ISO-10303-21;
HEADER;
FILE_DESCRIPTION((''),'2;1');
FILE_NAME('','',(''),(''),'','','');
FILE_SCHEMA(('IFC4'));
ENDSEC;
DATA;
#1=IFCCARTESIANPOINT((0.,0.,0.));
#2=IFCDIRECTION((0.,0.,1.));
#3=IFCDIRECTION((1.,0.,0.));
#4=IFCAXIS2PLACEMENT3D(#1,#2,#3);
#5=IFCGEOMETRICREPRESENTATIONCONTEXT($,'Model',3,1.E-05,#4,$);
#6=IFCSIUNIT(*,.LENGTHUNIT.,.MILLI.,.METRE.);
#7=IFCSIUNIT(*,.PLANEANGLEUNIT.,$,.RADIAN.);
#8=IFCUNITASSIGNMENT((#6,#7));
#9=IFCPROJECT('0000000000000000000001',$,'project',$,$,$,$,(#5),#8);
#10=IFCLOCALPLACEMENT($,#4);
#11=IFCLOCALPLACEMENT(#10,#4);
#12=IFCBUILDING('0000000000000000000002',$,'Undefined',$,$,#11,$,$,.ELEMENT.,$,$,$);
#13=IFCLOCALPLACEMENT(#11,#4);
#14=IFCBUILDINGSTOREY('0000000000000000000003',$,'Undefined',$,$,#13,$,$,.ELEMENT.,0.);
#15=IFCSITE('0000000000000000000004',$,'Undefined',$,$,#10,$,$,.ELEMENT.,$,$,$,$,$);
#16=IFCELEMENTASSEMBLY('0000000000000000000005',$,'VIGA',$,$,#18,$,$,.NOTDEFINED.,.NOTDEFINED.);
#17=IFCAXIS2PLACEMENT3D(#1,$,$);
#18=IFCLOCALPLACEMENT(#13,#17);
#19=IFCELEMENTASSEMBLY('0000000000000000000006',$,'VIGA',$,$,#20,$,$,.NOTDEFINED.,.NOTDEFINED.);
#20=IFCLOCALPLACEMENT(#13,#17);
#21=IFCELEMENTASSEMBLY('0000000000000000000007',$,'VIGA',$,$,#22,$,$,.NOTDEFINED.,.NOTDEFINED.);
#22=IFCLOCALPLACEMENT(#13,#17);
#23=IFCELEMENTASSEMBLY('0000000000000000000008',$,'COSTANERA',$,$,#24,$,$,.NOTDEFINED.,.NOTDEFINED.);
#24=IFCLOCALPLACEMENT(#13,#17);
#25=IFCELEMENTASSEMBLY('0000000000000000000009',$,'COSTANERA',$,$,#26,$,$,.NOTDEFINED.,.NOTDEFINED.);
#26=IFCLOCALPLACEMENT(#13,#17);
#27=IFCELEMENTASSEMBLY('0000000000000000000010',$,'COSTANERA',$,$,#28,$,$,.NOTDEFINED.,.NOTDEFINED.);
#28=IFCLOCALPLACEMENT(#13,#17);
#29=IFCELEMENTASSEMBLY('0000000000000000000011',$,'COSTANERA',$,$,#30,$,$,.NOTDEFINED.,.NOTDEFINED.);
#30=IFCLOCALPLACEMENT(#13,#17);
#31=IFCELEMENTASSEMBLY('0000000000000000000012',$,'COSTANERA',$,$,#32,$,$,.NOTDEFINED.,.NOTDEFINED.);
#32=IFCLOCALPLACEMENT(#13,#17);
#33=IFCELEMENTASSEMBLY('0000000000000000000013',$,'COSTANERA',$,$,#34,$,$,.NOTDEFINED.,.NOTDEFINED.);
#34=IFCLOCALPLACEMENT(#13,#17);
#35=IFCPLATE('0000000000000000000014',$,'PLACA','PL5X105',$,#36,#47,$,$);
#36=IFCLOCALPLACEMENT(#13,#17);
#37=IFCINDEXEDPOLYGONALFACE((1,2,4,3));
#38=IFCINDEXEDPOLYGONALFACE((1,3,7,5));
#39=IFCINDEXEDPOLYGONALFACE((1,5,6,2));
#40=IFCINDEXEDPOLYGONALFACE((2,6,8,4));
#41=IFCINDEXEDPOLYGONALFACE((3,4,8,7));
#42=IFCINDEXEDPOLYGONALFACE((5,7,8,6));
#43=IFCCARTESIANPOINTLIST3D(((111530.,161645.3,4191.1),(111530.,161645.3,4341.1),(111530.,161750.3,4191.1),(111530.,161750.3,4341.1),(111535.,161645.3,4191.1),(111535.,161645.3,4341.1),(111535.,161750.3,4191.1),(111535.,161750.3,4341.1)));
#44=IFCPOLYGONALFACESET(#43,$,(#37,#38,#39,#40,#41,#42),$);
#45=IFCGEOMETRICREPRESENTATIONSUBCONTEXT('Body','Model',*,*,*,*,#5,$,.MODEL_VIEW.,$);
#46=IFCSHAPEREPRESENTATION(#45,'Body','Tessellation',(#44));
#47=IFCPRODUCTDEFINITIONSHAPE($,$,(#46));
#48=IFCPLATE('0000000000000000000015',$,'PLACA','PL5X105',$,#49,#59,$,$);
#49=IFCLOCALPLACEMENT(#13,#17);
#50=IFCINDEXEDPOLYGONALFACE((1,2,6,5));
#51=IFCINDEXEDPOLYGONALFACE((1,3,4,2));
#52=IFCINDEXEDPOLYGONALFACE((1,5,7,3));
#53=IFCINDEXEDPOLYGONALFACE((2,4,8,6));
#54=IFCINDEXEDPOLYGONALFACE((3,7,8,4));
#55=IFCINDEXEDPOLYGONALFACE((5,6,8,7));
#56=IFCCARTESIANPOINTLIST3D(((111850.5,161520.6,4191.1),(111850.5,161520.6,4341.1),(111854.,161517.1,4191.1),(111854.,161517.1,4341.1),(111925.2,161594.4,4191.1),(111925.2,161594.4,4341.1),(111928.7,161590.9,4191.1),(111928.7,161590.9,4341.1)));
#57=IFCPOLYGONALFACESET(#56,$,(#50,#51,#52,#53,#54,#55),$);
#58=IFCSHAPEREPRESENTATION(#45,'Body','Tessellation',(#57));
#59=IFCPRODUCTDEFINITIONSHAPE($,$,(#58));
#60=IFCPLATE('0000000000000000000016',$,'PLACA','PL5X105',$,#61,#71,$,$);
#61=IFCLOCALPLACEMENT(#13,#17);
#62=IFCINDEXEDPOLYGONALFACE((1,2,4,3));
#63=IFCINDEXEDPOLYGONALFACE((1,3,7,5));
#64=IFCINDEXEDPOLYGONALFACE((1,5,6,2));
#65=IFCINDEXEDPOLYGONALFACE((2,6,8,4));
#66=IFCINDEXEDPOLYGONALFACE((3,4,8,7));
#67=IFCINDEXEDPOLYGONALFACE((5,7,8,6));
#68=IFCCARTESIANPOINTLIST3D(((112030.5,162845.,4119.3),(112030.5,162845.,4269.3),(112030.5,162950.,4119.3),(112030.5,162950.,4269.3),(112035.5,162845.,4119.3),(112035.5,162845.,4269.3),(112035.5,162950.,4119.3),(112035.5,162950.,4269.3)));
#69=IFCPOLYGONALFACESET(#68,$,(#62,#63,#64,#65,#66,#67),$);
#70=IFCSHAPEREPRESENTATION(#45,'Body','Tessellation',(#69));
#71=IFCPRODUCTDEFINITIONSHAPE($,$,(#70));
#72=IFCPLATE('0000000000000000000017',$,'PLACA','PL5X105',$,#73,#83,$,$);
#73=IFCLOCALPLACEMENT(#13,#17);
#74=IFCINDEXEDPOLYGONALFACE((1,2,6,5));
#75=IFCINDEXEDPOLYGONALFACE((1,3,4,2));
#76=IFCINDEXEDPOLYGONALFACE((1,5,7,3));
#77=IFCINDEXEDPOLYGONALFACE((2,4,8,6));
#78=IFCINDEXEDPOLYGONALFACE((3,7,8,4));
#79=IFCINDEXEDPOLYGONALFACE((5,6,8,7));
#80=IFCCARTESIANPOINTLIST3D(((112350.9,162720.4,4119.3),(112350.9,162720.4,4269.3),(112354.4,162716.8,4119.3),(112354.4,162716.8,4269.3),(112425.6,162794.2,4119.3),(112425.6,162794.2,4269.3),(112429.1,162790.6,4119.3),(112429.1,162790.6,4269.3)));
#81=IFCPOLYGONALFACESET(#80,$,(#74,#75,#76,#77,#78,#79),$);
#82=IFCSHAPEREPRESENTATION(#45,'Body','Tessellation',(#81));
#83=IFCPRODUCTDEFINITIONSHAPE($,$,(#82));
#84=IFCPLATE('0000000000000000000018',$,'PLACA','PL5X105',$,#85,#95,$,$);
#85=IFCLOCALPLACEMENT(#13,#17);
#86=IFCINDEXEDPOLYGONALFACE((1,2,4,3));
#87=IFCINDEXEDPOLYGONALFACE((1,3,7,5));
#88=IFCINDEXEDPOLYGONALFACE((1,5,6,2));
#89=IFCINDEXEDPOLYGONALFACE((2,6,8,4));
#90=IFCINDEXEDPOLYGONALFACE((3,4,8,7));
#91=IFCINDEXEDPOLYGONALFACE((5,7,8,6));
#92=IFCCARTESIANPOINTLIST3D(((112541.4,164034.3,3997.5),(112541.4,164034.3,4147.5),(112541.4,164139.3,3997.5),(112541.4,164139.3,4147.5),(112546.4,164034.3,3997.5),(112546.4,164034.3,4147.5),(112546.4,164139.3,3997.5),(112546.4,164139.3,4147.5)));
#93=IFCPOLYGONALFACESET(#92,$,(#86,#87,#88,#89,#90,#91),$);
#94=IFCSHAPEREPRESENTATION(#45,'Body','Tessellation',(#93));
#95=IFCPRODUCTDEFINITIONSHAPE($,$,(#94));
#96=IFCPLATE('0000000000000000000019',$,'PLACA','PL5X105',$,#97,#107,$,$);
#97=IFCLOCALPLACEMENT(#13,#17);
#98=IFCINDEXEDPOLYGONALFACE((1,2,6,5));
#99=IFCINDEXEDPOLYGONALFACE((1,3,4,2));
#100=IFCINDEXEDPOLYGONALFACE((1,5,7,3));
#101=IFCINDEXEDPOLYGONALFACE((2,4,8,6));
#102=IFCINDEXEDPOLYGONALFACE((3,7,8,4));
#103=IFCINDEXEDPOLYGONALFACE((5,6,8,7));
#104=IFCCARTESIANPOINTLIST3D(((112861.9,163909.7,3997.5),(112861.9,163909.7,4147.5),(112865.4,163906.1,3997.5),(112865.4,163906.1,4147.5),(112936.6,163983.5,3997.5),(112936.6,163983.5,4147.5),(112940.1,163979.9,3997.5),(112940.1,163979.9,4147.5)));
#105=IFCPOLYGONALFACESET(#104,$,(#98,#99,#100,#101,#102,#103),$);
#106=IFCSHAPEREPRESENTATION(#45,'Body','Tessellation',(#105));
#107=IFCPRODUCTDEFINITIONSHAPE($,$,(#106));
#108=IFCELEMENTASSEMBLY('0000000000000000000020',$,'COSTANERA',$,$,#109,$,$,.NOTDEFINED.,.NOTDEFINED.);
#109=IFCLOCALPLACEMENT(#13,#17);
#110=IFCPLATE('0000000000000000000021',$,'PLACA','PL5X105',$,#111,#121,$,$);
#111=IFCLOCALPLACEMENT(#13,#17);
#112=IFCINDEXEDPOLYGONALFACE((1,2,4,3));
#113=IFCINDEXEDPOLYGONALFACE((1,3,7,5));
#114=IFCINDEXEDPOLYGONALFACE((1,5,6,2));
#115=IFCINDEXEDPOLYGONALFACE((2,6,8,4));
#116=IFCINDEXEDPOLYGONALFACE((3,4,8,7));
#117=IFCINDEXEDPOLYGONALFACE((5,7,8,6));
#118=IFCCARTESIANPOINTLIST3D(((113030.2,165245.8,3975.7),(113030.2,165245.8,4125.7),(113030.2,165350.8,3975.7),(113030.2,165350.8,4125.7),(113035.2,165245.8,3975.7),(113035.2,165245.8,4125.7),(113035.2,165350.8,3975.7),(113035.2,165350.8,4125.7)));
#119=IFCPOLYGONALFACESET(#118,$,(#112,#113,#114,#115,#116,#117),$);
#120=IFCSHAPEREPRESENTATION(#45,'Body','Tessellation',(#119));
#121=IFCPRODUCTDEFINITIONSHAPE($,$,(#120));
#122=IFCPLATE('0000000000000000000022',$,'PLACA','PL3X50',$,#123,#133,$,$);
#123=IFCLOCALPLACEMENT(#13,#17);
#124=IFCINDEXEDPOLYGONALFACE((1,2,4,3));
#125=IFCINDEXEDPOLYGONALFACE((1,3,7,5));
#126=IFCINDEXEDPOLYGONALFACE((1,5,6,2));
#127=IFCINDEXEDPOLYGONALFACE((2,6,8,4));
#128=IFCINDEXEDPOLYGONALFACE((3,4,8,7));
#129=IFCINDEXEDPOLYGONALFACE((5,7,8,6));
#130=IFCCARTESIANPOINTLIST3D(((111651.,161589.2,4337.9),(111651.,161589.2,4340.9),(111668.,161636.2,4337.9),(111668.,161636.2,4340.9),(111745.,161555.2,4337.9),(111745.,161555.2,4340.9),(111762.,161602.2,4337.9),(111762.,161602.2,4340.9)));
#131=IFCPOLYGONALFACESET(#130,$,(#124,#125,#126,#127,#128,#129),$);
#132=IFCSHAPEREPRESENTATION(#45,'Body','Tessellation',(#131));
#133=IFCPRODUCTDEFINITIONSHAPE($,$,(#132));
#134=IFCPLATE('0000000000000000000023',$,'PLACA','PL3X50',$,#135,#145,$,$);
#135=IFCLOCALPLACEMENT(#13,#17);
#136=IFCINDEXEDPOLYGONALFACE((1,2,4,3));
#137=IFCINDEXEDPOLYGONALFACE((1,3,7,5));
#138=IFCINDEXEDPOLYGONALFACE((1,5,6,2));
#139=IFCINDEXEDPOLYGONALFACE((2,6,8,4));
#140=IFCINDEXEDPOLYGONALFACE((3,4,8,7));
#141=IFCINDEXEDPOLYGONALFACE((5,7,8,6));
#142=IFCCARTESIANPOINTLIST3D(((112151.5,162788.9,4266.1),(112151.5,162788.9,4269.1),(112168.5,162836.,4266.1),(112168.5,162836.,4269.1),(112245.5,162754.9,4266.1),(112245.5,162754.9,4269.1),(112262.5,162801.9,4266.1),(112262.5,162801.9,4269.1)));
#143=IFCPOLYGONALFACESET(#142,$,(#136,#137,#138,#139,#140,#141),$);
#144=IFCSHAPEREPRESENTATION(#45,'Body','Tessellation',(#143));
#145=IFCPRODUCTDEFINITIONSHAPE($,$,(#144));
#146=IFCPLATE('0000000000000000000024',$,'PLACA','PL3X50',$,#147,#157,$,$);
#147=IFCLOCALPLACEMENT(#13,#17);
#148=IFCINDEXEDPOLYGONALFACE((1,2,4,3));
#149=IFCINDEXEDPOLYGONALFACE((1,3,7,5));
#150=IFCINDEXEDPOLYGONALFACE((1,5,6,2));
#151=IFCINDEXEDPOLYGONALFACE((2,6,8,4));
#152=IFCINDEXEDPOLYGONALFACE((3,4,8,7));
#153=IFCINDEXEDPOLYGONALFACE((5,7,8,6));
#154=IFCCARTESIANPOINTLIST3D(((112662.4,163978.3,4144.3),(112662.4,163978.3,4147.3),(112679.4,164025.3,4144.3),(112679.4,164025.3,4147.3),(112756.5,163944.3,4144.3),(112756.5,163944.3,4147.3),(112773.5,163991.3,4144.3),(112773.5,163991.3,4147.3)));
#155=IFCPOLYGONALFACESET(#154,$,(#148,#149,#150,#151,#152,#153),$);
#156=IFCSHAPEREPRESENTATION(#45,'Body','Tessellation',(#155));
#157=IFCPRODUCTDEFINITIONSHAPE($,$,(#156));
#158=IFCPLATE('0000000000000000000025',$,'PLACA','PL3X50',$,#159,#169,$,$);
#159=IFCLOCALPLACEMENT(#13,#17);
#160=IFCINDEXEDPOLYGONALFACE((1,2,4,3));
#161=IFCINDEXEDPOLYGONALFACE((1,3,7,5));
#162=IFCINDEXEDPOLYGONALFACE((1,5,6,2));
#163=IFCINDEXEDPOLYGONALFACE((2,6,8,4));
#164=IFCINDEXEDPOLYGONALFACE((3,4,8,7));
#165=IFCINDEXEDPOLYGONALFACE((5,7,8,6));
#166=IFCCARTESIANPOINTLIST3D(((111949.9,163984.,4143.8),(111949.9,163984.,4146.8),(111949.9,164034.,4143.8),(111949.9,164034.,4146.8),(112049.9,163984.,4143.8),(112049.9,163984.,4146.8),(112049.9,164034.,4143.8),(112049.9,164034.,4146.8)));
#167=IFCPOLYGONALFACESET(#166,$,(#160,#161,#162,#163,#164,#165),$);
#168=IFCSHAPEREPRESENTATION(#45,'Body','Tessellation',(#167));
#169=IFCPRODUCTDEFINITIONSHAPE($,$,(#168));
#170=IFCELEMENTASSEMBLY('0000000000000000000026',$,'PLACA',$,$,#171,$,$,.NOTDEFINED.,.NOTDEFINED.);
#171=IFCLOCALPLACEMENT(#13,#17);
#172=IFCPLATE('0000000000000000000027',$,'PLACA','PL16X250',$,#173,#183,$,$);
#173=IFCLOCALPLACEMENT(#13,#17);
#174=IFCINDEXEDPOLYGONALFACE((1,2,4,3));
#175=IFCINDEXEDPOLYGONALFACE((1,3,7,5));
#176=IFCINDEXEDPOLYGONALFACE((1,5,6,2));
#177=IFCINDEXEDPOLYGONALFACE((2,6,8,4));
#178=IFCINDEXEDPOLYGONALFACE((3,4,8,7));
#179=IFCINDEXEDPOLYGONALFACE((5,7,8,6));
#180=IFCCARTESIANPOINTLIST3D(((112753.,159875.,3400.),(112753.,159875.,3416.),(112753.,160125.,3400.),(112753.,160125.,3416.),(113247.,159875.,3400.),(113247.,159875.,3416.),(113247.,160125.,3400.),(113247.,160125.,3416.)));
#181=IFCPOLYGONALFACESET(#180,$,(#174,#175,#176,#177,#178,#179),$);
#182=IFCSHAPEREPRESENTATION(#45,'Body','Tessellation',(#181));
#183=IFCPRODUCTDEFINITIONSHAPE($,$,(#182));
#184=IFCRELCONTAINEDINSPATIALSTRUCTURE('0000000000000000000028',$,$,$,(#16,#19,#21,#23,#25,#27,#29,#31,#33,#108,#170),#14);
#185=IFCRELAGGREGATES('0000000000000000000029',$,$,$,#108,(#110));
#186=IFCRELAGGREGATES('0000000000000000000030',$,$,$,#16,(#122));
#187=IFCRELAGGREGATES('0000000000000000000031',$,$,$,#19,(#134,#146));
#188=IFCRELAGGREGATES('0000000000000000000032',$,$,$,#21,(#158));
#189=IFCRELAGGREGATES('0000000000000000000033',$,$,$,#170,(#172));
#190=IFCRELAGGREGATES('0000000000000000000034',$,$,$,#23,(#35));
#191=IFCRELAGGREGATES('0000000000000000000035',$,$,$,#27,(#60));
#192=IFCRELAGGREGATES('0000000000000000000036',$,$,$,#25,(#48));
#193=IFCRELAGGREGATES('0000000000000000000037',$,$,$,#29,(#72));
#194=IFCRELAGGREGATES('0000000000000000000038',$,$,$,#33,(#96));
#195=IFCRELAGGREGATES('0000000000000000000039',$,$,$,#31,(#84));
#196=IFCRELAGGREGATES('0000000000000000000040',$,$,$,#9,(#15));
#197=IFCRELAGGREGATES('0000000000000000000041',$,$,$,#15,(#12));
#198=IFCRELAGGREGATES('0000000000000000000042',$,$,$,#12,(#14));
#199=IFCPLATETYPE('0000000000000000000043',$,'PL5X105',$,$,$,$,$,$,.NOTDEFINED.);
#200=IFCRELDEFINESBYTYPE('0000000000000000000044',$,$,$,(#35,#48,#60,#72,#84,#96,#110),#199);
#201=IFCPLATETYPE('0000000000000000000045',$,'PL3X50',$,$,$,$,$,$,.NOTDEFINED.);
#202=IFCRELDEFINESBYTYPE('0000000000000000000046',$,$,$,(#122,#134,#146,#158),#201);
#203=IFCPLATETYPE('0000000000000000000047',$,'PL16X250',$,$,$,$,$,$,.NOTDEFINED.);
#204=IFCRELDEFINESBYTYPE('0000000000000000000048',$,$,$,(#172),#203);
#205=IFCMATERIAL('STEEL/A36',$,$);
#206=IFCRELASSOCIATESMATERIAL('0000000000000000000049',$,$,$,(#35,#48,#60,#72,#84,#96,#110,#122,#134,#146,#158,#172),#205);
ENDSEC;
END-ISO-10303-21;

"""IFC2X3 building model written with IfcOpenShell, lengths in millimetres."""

from ifc_helpers import new_model, si_unit, frame, origin_with_axes, place, context, subcontext, project, spatial, polyline, outline, extrude, material, type_object, element, aggregate, save


model = new_model("IFC2X3")

# Units and contexts
model_context = context("Model", 3, precision=1e-05, world=origin_with_axes())
body_context = subcontext(model_context, "Body", "Model", "MODEL_VIEW")
ifc_project = project(units=[si_unit("LENGTHUNIT", "METRE", prefix="MILLI"), si_unit("PLANEANGLEUNIT", "RADIAN")], contexts=[model_context])

# Site, building, storey
site_placement = place(None, origin_with_axes())
site = spatial("IfcSite", under=ifc_project, at=site_placement, Name="Undefined", CompositionType="ELEMENT")
building_placement = place(site_placement, origin_with_axes())
building = spatial("IfcBuilding", under=site, at=building_placement, Name="Undefined", CompositionType="ELEMENT")
storey_placement = place(building_placement, origin_with_axes())
storey = spatial("IfcBuildingStorey", under=building, at=storey_placement, Name="Undefined", CompositionType="ELEMENT", Elevation=0.0)

# Element assembly
assembly_1_placement = place(storey_placement, origin_with_axes())
assembly_1 = element("IfcElementAssembly", 1, at=assembly_1_placement, inside=storey, Name="VIGA", AssemblyPlace="NOTDEFINED", PredefinedType="NOTDEFINED")
ifc_material_1 = material(Name="STEEL/A36")

# Element assemblies
assembly_2_placement = place(storey_placement, origin_with_axes())
assembly_2 = element("IfcElementAssembly", 2, at=assembly_2_placement, inside=storey, Name="VIGA", AssemblyPlace="NOTDEFINED", PredefinedType="NOTDEFINED")
assembly_3_placement = place(storey_placement, origin_with_axes())
assembly_3 = element("IfcElementAssembly", 3, at=assembly_3_placement, inside=storey, Name="VIGA", AssemblyPlace="NOTDEFINED", PredefinedType="NOTDEFINED")

# Element assemblies
assembly_4_placement = place(storey_placement, origin_with_axes())
assembly_4 = element("IfcElementAssembly", 4, at=assembly_4_placement, inside=storey, Name="COSTANERA", AssemblyPlace="NOTDEFINED", PredefinedType="NOTDEFINED")
assembly_5_placement = place(storey_placement, origin_with_axes())
assembly_5 = element("IfcElementAssembly", 5, at=assembly_5_placement, inside=storey, Name="COSTANERA", AssemblyPlace="NOTDEFINED", PredefinedType="NOTDEFINED")
assembly_6_placement = place(storey_placement, origin_with_axes())
assembly_6 = element("IfcElementAssembly", 6, at=assembly_6_placement, inside=storey, Name="COSTANERA", AssemblyPlace="NOTDEFINED", PredefinedType="NOTDEFINED")
assembly_7_placement = place(storey_placement, origin_with_axes())
assembly_7 = element("IfcElementAssembly", 7, at=assembly_7_placement, inside=storey, Name="COSTANERA", AssemblyPlace="NOTDEFINED", PredefinedType="NOTDEFINED")
assembly_8_placement = place(storey_placement, origin_with_axes())
assembly_8 = element("IfcElementAssembly", 8, at=assembly_8_placement, inside=storey, Name="COSTANERA", AssemblyPlace="NOTDEFINED", PredefinedType="NOTDEFINED")
assembly_9_placement = place(storey_placement, origin_with_axes())
assembly_9 = element("IfcElementAssembly", 9, at=assembly_9_placement, inside=storey, Name="COSTANERA", AssemblyPlace="NOTDEFINED", PredefinedType="NOTDEFINED")

# Plates
plate_type_1 = type_object("IfcPlateType", Name="PL5X105", PredefinedType="NOTDEFINED")
plate_1_placement = place(assembly_4_placement, frame((111532.5, 161645.3, 4341.1), z_axis=(-1.0, 0.0, 0.000004), x_axis=(0.0, 1.0, -0.000004)))
plate_1 = element("IfcPlate", 10, at=plate_1_placement, type_object=plate_type_1, material=ifc_material_1, Name="PLACA", Description="PL5X105", context=body_context, shape_type="SweptSolid", body=[
    extrude(outline(polyline([(0.0, 0.0), (105.0, 0.0), (105.0, 150.0), (0.0, 150.0), (0.0, 0.0)])), frame((0.0, 0.0, -2.5), z_axis=(0.0, 0.0, 1.0), x_axis=(1.0, 0.0, 0.0)), (0.0, 0.0, 1.0), 5.0),
])
plate_2_placement = place(assembly_5_placement, frame((111852.2, 161518.8, 4191.1), z_axis=(0.702758, -0.711429, 0.0), x_axis=(0.711429, 0.702758, -0.000006)))
plate_2 = element("IfcPlate", 11, at=plate_2_placement, type_object=plate_type_1, material=ifc_material_1, Name="PLACA", Description="PL5X105", context=body_context, shape_type="SweptSolid", body=[
    extrude(outline(polyline([(0.0, 0.0), (105.0, 0.0), (105.0, 150.0), (0.0, 150.0), (0.0, 0.0)])), frame((0.0, 0.0, -2.5), z_axis=(0.0, 0.0, 1.0), x_axis=(1.0, 0.0, 0.0)), (0.0, 0.0, 1.0), 5.0),
])
plate_3_placement = place(assembly_6_placement, frame((112033.0, 162845.0, 4269.3), z_axis=(-1.0, 0.0, 0.000004), x_axis=(0.0, 1.0, -0.000004)))
plate_3 = element("IfcPlate", 12, at=plate_3_placement, type_object=plate_type_1, material=ifc_material_1, Name="PLACA", Description="PL5X105", context=body_context, shape_type="SweptSolid", body=[
    extrude(outline(polyline([(0.0, 0.0), (105.0, 0.0), (105.0, 150.0), (0.0, 150.0), (0.0, 0.0)])), frame((0.0, 0.0, -2.5), z_axis=(0.0, 0.0, 1.0), x_axis=(1.0, 0.0, 0.0)), (0.0, 0.0, 1.0), 5.0),
])
plate_4_placement = place(assembly_7_placement, frame((112352.7, 162718.6, 4119.3), z_axis=(0.702758, -0.711429, 0.0), x_axis=(0.711429, 0.702758, -0.000006)))
plate_4 = element("IfcPlate", 13, at=plate_4_placement, type_object=plate_type_1, material=ifc_material_1, Name="PLACA", Description="PL5X105", context=body_context, shape_type="SweptSolid", body=[
    extrude(outline(polyline([(0.0, 0.0), (105.0, 0.0), (105.0, 150.0), (0.0, 150.0), (0.0, 0.0)])), frame((0.0, 0.0, -2.5), z_axis=(0.0, 0.0, 1.0), x_axis=(1.0, 0.0, 0.0)), (0.0, 0.0, 1.0), 5.0),
])
plate_5_placement = place(assembly_8_placement, frame((112543.9, 164034.3, 4147.5), z_axis=(-1.0, 0.0, 0.000004), x_axis=(0.0, 1.0, -0.000004)))
plate_5 = element("IfcPlate", 14, at=plate_5_placement, type_object=plate_type_1, material=ifc_material_1, Name="PLACA", Description="PL5X105", context=body_context, shape_type="SweptSolid", body=[
    extrude(outline(polyline([(0.0, 0.0), (105.0, 0.0), (105.0, 150.0), (0.0, 150.0), (0.0, 0.0)])), frame((0.0, 0.0, -2.5), z_axis=(0.0, 0.0, 1.0), x_axis=(1.0, 0.0, 0.0)), (0.0, 0.0, 1.0), 5.0),
])
plate_6_placement = place(assembly_9_placement, frame((112863.7, 163907.9, 3997.5), z_axis=(0.702758, -0.711429, 0.0), x_axis=(0.711429, 0.702758, -0.000006)))
plate_6 = element("IfcPlate", 15, at=plate_6_placement, type_object=plate_type_1, material=ifc_material_1, Name="PLACA", Description="PL5X105", context=body_context, shape_type="SweptSolid", body=[
    extrude(outline(polyline([(0.0, 0.0), (105.0, 0.0), (105.0, 150.0), (0.0, 150.0), (0.0, 0.0)])), frame((0.0, 0.0, -2.5), z_axis=(0.0, 0.0, 1.0), x_axis=(1.0, 0.0, 0.0)), (0.0, 0.0, 1.0), 5.0),
])

# Element assembly, plate
assembly_10_placement = place(storey_placement, origin_with_axes())
assembly_10 = element("IfcElementAssembly", 16, at=assembly_10_placement, inside=storey, Name="COSTANERA", AssemblyPlace="NOTDEFINED", PredefinedType="NOTDEFINED")
plate_7_placement = place(assembly_10_placement, frame((113032.7, 165245.8, 4125.7), z_axis=(-1.0, 0.0, 0.000004), x_axis=(0.0, 1.0, -0.000004)))
plate_7 = element("IfcPlate", 17, at=plate_7_placement, type_object=plate_type_1, material=ifc_material_1, Name="PLACA", Description="PL5X105", context=body_context, shape_type="SweptSolid", body=[
    extrude(outline(polyline([(0.0, 0.0), (105.0, 0.0), (105.0, 150.0), (0.0, 150.0), (0.0, 0.0)])), frame((0.0, 0.0, -2.5), z_axis=(0.0, 0.0, 1.0), x_axis=(1.0, 0.0, 0.0)), (0.0, 0.0, 1.0), 5.0),
])
aggregate(assembly_10, [plate_7])

# Plates
plate_type_2 = type_object("IfcPlateType", Name="PL3X50", PredefinedType="NOTDEFINED")
plate_8_placement = place(assembly_1_placement, frame((111668.0, 161636.2, 4339.4), z_axis=(0.000004, 0.000004, 1.0), x_axis=(-0.340049, -0.940408, 0.000005)))
plate_8 = element("IfcPlate", 18, at=plate_8_placement, type_object=plate_type_2, material=ifc_material_1, Name="PLACA", Description="PL3X50", context=body_context, shape_type="SweptSolid", body=[
    extrude(outline(polyline([(0.0, 0.0), (50.0, 0.0), (50.0, 100.0), (0.0, 100.0), (0.0, 0.0)])), frame((0.0, 0.0, -1.5), z_axis=(0.0, 0.0, 1.0), x_axis=(1.0, 0.0, 0.0)), (0.0, 0.0, 1.0), 3.0),
])
aggregate(assembly_1, [plate_8])
plate_9_placement = place(assembly_2_placement, frame((112168.5, 162836.0, 4267.6), z_axis=(0.000004, 0.000004, 1.0), x_axis=(-0.340049, -0.940408, 0.000005)))
plate_9 = element("IfcPlate", 19, at=plate_9_placement, type_object=plate_type_2, material=ifc_material_1, Name="PLACA", Description="PL3X50", context=body_context, shape_type="SweptSolid", body=[
    extrude(outline(polyline([(0.0, 0.0), (50.0, 0.0), (50.0, 100.0), (0.0, 100.0), (0.0, 0.0)])), frame((0.0, 0.0, -1.5), z_axis=(0.0, 0.0, 1.0), x_axis=(1.0, 0.0, 0.0)), (0.0, 0.0, 1.0), 3.0),
])
plate_10_placement = place(assembly_2_placement, frame((112679.4, 164025.3, 4145.8), z_axis=(0.000004, 0.000004, 1.0), x_axis=(-0.340049, -0.940408, 0.000005)))
plate_10 = element("IfcPlate", 20, at=plate_10_placement, type_object=plate_type_2, material=ifc_material_1, Name="PLACA", Description="PL3X50", context=body_context, shape_type="SweptSolid", body=[
    extrude(outline(polyline([(0.0, 0.0), (50.0, 0.0), (50.0, 100.0), (0.0, 100.0), (0.0, 0.0)])), frame((0.0, 0.0, -1.5), z_axis=(0.0, 0.0, 1.0), x_axis=(1.0, 0.0, 0.0)), (0.0, 0.0, 1.0), 3.0),
])
aggregate(assembly_2, [plate_9, plate_10])
plate_11_placement = place(assembly_3_placement, frame((112049.9, 164034.0, 4145.3), z_axis=(-0.000002, 0.0, 1.0), x_axis=(-1.0, 0.0, -0.000002)))
plate_11 = element("IfcPlate", 21, at=plate_11_placement, type_object=plate_type_2, material=ifc_material_1, Name="PLACA", Description="PL3X50", context=body_context, shape_type="SweptSolid", body=[
    extrude(outline(polyline([(0.0, 0.0), (100.0, 0.0), (100.0, 50.0), (0.0, 50.0), (0.0, 0.0)])), frame((0.0, 0.0, -1.5), z_axis=(0.0, 0.0, 1.0), x_axis=(1.0, 0.0, 0.0)), (0.0, 0.0, 1.0), 3.0),
])
aggregate(assembly_3, [plate_11])

# Element assembly, plate
assembly_11_placement = place(storey_placement, origin_with_axes())
assembly_11 = element("IfcElementAssembly", 22, at=assembly_11_placement, inside=storey, Name="PLACA", AssemblyPlace="NOTDEFINED", PredefinedType="NOTDEFINED")
plate_type_3 = type_object("IfcPlateType", Name="PL16X250", PredefinedType="NOTDEFINED")
plate_12_placement = place(assembly_11_placement, frame((112753.0, 160000.0, 3408.0), z_axis=(0.0, 0.0, -1.0), x_axis=(1.0, 0.0, 0.0)))
plate_12 = element("IfcPlate", 23, at=plate_12_placement, type_object=plate_type_3, material=ifc_material_1, Name="PLACA", Description="PL16X250", context=body_context, shape_type="SweptSolid", body=[
    extrude(outline(polyline([(0.0, -125.0), (0.0, 125.0), (494.0, 125.0), (494.0, -125.0), (0.0, -125.0)])), frame((0.0, 0.0, -8.0), z_axis=(0.0, 0.0, 1.0), x_axis=(1.0, 0.0, 0.0)), (0.0, 0.0, 1.0), 16.0),
])
aggregate(assembly_11, [plate_12])

aggregate(assembly_4, [plate_1])
aggregate(assembly_6, [plate_3])
aggregate(assembly_5, [plate_2])
aggregate(assembly_7, [plate_4])
aggregate(assembly_9, [plate_6])
aggregate(assembly_8, [plate_5])

save(model, "model.ifc")
